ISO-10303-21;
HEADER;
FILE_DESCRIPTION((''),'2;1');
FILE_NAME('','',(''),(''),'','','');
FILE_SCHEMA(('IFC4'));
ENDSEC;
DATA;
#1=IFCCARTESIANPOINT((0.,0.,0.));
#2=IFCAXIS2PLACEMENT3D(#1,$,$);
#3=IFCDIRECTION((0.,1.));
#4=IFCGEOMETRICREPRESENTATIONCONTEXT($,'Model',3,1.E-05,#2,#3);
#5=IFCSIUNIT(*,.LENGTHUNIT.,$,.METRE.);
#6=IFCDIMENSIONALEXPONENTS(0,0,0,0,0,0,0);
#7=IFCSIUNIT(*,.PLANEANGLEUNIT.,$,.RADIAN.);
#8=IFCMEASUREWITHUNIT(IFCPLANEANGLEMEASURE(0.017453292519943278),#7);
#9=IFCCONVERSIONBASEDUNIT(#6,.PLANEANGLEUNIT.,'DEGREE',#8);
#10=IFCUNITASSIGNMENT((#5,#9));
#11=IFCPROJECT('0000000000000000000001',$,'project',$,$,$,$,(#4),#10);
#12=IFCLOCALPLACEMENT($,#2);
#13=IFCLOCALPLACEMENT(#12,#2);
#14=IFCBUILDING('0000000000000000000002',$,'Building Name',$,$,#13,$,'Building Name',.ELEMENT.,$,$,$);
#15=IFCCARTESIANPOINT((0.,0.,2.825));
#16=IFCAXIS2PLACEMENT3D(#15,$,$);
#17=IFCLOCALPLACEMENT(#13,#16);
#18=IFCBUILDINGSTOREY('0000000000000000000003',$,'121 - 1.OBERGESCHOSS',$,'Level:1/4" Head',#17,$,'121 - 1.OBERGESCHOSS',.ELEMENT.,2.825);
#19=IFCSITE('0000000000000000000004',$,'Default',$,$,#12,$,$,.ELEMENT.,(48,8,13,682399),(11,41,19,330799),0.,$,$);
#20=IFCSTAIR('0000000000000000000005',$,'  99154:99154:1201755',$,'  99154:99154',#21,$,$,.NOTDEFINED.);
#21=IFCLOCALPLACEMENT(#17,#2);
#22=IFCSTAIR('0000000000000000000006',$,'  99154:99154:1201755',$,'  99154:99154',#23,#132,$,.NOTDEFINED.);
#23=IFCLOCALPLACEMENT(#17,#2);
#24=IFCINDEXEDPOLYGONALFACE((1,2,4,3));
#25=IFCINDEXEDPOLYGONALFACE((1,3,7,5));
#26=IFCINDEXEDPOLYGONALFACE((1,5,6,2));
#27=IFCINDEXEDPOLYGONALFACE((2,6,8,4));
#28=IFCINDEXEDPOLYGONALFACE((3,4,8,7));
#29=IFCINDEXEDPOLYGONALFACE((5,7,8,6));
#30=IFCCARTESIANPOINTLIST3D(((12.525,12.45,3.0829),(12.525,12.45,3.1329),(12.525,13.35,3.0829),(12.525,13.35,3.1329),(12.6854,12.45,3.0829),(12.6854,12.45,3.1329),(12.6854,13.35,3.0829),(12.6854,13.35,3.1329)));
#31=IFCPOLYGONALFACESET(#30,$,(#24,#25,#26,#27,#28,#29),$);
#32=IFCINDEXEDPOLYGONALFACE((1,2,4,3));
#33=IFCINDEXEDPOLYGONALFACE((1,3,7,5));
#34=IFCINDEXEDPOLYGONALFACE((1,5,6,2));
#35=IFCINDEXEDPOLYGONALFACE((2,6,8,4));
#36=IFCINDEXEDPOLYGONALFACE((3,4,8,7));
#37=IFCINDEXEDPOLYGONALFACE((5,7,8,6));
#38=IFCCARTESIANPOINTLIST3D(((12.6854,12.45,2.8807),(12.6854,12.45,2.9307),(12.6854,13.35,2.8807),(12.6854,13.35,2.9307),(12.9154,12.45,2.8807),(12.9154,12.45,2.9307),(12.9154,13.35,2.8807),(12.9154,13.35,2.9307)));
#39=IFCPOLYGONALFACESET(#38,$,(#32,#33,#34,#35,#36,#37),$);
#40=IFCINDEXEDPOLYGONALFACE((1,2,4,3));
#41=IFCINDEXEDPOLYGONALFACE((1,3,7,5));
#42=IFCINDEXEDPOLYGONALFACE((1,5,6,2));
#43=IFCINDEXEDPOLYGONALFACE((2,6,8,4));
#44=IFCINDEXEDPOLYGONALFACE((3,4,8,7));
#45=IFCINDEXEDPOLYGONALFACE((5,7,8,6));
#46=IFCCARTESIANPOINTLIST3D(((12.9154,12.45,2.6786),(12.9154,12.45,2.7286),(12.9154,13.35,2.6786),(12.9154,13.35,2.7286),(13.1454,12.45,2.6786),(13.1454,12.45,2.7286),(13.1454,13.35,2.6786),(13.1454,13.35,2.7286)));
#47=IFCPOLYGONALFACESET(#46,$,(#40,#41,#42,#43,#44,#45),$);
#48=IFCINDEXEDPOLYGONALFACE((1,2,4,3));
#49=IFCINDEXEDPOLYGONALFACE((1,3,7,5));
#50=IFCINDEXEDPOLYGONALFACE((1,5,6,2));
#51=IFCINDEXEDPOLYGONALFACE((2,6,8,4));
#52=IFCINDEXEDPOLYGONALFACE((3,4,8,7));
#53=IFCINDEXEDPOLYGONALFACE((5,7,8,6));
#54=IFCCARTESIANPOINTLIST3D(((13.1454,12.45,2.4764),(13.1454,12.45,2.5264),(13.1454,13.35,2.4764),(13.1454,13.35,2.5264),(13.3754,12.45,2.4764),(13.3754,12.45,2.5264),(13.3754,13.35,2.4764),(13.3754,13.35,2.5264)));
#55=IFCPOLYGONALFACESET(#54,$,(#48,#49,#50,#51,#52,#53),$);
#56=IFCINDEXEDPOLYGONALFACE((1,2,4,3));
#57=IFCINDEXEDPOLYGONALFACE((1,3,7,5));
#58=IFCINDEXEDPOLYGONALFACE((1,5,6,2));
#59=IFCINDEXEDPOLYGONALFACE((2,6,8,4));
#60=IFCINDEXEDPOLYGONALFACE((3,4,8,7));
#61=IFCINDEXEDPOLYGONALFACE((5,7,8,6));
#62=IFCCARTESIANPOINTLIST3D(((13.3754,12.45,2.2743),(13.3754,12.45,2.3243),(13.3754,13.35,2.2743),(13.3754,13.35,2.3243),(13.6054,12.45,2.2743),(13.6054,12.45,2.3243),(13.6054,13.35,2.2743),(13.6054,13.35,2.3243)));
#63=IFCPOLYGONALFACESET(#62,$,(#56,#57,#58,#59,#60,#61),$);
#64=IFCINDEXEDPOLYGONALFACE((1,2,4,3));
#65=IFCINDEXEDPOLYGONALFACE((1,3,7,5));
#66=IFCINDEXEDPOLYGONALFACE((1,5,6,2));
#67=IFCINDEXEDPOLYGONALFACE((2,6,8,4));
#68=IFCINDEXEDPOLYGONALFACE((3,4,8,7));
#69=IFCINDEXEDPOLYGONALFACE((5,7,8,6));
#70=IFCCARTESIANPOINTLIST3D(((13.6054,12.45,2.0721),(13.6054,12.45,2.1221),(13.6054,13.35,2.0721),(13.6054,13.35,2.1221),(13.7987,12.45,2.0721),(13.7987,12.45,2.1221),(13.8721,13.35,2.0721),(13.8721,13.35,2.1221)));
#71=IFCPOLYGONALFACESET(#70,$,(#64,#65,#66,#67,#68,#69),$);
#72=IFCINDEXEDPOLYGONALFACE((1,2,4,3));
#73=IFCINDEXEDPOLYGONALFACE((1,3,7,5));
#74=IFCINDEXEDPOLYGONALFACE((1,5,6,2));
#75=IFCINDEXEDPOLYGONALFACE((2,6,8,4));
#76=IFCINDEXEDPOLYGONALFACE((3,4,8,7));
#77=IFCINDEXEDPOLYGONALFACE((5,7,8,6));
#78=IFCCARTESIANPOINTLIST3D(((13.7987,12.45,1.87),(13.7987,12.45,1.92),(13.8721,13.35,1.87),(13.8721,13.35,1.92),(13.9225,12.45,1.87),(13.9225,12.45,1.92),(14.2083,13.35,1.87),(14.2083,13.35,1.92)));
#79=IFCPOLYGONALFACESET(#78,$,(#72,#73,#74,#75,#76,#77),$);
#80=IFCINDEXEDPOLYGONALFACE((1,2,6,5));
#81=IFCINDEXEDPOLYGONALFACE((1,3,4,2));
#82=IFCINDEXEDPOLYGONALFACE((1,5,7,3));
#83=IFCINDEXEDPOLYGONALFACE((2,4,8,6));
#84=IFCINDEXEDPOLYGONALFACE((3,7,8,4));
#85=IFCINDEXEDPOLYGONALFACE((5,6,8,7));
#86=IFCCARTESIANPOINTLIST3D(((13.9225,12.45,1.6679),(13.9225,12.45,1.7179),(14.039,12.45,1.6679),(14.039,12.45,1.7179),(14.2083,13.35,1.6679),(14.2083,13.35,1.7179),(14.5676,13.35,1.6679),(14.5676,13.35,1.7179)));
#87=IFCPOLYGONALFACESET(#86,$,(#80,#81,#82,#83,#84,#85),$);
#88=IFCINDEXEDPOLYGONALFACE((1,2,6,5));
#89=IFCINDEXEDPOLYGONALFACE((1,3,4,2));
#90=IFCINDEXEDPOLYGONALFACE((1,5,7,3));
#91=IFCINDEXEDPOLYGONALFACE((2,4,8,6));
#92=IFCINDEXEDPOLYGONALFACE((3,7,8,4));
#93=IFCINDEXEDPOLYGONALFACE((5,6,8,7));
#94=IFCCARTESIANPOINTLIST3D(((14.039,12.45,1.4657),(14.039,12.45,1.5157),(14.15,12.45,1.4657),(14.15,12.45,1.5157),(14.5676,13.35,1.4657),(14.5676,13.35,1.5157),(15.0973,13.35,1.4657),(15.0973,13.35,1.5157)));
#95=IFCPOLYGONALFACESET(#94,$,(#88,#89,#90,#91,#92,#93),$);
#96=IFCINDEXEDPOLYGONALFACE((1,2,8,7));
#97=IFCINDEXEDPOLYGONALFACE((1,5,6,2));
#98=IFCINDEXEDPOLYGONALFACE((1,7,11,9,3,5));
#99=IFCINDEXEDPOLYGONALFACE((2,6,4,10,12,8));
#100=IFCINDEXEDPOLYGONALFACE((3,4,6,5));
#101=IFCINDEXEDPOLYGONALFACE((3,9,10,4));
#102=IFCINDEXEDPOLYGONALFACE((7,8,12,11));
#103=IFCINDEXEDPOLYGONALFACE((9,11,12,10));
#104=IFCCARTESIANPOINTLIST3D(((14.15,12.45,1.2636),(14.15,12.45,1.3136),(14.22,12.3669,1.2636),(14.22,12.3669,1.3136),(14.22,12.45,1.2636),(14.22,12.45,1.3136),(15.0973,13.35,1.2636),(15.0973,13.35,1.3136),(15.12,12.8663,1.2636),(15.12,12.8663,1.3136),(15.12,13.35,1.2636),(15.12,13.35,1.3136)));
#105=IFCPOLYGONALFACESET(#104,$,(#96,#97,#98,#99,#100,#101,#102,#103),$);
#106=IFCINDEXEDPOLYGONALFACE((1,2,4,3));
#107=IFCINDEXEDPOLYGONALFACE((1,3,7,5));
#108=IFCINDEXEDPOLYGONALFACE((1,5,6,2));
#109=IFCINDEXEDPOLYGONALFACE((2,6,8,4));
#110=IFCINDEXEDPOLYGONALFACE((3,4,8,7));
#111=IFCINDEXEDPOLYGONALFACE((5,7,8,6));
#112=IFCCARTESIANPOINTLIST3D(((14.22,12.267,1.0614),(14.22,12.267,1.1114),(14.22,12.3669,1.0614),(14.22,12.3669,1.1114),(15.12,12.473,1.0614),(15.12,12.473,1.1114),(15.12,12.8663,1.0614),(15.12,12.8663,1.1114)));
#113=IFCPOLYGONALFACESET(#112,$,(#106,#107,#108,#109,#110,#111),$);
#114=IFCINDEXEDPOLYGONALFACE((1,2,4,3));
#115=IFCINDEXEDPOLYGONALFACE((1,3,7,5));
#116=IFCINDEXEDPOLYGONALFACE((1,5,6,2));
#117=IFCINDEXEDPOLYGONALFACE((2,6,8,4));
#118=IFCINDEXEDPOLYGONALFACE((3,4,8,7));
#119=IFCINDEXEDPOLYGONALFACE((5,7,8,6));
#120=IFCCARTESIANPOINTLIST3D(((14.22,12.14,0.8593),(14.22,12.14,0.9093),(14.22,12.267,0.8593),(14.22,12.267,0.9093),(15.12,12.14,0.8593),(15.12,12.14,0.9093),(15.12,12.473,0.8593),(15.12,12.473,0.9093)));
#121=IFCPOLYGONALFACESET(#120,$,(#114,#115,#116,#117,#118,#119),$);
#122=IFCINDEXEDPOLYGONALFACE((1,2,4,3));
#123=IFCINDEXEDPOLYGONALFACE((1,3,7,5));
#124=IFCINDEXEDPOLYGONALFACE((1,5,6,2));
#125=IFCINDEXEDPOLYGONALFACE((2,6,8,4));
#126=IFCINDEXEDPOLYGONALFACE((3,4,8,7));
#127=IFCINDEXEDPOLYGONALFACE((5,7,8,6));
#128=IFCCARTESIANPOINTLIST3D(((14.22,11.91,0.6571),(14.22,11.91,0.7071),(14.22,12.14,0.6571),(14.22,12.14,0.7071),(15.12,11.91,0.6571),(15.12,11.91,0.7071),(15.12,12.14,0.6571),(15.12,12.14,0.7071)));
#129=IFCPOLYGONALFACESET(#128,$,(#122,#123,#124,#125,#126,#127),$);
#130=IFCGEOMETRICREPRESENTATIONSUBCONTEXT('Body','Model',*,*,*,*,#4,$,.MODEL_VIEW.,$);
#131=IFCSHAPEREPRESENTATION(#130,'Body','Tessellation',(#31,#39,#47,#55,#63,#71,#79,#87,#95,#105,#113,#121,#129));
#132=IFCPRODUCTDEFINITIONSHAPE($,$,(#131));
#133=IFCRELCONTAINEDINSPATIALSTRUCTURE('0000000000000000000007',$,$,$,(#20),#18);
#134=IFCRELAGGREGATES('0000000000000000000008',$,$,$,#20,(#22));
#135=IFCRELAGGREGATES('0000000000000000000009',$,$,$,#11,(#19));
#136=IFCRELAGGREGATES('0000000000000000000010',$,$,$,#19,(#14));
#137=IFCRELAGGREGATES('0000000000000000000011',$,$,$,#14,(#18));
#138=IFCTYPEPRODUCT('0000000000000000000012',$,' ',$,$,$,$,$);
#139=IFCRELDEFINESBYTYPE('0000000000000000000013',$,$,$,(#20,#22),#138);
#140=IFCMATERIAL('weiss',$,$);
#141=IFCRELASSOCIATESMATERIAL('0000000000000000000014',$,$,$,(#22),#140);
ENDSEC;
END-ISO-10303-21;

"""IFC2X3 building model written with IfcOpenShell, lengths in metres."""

from ifc_helpers import new_model, entity, si_unit, converted_unit, direction, frame, origin, origin_2d_with_axis, place, context, subcontext, project, spatial, polyline, rectangle, outline, extrude, material, type_object, element, aggregate, save


model = new_model("IFC2X3")

# Units and contexts
model_context = context("Model", 3, precision=1e-05, world=origin(), true_north=direction((0.0, 1.0)))
body_context = subcontext(model_context, "Body", "Model", "MODEL_VIEW")
ifc_project = project(units=[si_unit("LENGTHUNIT", "METRE"), converted_unit("PLANEANGLEUNIT", "DEGREE", entity("IfcPlaneAngleMeasure", 0.017453292519943278), si_unit("PLANEANGLEUNIT", "RADIAN"), dimensions=[0, 0, 0, 0, 0, 0, 0])], contexts=[model_context])

# Site, building, storey
site_placement = place(None, origin())
site = spatial("IfcSite", under=ifc_project, at=site_placement, Name="Default", CompositionType="ELEMENT", RefLatitude=(48, 8, 13, 682399), RefLongitude=(11, 41, 19, 330799), RefElevation=0.0)
building_placement = place(site_placement, origin())
building = spatial("IfcBuilding", under=site, at=building_placement, Name="Building Name", LongName="Building Name", CompositionType="ELEMENT")
storey_placement = place(building_placement, frame((0.0, 0.0, 2.825)))
storey = spatial("IfcBuildingStorey", under=building, at=storey_placement, Name="121 - 1.OBERGESCHOSS", ObjectType="Level:1/4\" Head", LongName="121 - 1.OBERGESCHOSS", CompositionType="ELEMENT", Elevation=2.825)

# Stairs
ifc_material_1 = material(Name="weiss")
type_product_1 = type_object("IfcTypeProduct", Name=" ")
stair_1_placement = place(storey_placement, origin())
stair_1 = element("IfcStair", 1, at=stair_1_placement, inside=storey, type_object=type_product_1, Name="  99154:99154:1201755", ObjectType="  99154:99154", ShapeType="NOTDEFINED")
stair_2_placement = place(stair_1_placement, origin())
stair_2 = element("IfcStair", 2, at=stair_2_placement, type_object=type_product_1, material=ifc_material_1, Name="  99154:99154:1201755", ObjectType="  99154:99154", ShapeType="NOTDEFINED", context=body_context, shape_type="SweptSolid", body=[
    extrude(rectangle(XDim=0.1604, YDim=0.9, at=origin_2d_with_axis()), frame((12.6052, 12.9, 3.0829)), (0.0, 0.0, 1.0), 0.05),
    extrude(rectangle(XDim=0.23, YDim=0.9, at=origin_2d_with_axis()), frame((12.8004, 12.9, 2.8807)), (0.0, 0.0, 1.0), 0.05),
    extrude(rectangle(XDim=0.23, YDim=0.9, at=origin_2d_with_axis()), frame((13.0304, 12.9, 2.6786)), (0.0, 0.0, 1.0), 0.05),
    extrude(rectangle(XDim=0.23, YDim=0.9, at=origin_2d_with_axis()), frame((13.2604, 12.9, 2.4764)), (0.0, 0.0, 1.0), 0.05),
    extrude(rectangle(XDim=0.23, YDim=0.9, at=origin_2d_with_axis()), frame((13.4904, 12.9, 2.2743)), (0.0, 0.0, 1.0), 0.05),
    extrude(outline(polyline([(-0.115, -0.45), (0.0783, -0.45), (0.1517, 0.45), (-0.115, 0.45), (-0.115, -0.45)])), frame((13.7204, 12.9, 2.0721)), (0.0, 0.0, 1.0), 0.05),
    extrude(outline(polyline([(-0.1517, -0.45), (-0.0279, -0.45), (0.2579, 0.45), (-0.0783, 0.45), (-0.1517, -0.45)])), frame((13.9504, 12.9, 1.87)), (0.0, 0.0, 1.0), 0.05),
    extrude(outline(polyline([(-0.2619, -0.45), (-0.1453, -0.45), (0.3832, 0.45), (0.024, 0.45), (-0.2619, -0.45)])), frame((14.1843, 12.9, 1.6679)), (0.0, 0.0, 1.0), 0.05),
    extrude(outline(polyline([(-0.4245, -0.45), (-0.3135, -0.45), (0.6339, 0.45), (0.1041, 0.45), (-0.4245, -0.45)])), frame((14.4635, 12.9, 1.4657)), (0.0, 0.0, 1.0), 0.05),
    extrude(outline(polyline([(0.3555, -0.4346), (0.4386, -0.4346), (-0.0608, 0.4654), (-0.5445, 0.4654), (-0.5445, 0.4428), (0.3555, -0.5046), (0.3555, -0.4346)])), frame((14.6546, 12.8055, 1.2636), z_axis=(0.0, 0.0, 1.0), x_axis=(0.0, -1.0, 0.0)), (0.0, 0.0, 1.0), 0.05),
    extrude(outline(polyline([(0.1264, -0.45), (0.2263, -0.45), (0.0203, 0.45), (-0.373, 0.45), (0.1264, -0.45)])), frame((14.67, 12.4933, 1.0614), z_axis=(0.0, 0.0, 1.0), x_axis=(0.0, -1.0, 0.0)), (0.0, 0.0, 1.0), 0.05),
    extrude(outline(polyline([(-0.012, -0.45), (0.115, -0.45), (0.115, 0.45), (-0.218, 0.45), (-0.012, -0.45)])), frame((14.67, 12.255, 0.8593), z_axis=(0.0, 0.0, 1.0), x_axis=(0.0, -1.0, 0.0)), (0.0, 0.0, 1.0), 0.05),
    extrude(rectangle(XDim=0.23, YDim=0.9, at=origin_2d_with_axis()), frame((14.67, 12.025, 0.6571), z_axis=(0.0, 0.0, 1.0), x_axis=(0.0, -1.0, 0.0)), (0.0, 0.0, 1.0), 0.05),
])
aggregate(stair_1, [stair_2])

save(model, "model.ifc")
